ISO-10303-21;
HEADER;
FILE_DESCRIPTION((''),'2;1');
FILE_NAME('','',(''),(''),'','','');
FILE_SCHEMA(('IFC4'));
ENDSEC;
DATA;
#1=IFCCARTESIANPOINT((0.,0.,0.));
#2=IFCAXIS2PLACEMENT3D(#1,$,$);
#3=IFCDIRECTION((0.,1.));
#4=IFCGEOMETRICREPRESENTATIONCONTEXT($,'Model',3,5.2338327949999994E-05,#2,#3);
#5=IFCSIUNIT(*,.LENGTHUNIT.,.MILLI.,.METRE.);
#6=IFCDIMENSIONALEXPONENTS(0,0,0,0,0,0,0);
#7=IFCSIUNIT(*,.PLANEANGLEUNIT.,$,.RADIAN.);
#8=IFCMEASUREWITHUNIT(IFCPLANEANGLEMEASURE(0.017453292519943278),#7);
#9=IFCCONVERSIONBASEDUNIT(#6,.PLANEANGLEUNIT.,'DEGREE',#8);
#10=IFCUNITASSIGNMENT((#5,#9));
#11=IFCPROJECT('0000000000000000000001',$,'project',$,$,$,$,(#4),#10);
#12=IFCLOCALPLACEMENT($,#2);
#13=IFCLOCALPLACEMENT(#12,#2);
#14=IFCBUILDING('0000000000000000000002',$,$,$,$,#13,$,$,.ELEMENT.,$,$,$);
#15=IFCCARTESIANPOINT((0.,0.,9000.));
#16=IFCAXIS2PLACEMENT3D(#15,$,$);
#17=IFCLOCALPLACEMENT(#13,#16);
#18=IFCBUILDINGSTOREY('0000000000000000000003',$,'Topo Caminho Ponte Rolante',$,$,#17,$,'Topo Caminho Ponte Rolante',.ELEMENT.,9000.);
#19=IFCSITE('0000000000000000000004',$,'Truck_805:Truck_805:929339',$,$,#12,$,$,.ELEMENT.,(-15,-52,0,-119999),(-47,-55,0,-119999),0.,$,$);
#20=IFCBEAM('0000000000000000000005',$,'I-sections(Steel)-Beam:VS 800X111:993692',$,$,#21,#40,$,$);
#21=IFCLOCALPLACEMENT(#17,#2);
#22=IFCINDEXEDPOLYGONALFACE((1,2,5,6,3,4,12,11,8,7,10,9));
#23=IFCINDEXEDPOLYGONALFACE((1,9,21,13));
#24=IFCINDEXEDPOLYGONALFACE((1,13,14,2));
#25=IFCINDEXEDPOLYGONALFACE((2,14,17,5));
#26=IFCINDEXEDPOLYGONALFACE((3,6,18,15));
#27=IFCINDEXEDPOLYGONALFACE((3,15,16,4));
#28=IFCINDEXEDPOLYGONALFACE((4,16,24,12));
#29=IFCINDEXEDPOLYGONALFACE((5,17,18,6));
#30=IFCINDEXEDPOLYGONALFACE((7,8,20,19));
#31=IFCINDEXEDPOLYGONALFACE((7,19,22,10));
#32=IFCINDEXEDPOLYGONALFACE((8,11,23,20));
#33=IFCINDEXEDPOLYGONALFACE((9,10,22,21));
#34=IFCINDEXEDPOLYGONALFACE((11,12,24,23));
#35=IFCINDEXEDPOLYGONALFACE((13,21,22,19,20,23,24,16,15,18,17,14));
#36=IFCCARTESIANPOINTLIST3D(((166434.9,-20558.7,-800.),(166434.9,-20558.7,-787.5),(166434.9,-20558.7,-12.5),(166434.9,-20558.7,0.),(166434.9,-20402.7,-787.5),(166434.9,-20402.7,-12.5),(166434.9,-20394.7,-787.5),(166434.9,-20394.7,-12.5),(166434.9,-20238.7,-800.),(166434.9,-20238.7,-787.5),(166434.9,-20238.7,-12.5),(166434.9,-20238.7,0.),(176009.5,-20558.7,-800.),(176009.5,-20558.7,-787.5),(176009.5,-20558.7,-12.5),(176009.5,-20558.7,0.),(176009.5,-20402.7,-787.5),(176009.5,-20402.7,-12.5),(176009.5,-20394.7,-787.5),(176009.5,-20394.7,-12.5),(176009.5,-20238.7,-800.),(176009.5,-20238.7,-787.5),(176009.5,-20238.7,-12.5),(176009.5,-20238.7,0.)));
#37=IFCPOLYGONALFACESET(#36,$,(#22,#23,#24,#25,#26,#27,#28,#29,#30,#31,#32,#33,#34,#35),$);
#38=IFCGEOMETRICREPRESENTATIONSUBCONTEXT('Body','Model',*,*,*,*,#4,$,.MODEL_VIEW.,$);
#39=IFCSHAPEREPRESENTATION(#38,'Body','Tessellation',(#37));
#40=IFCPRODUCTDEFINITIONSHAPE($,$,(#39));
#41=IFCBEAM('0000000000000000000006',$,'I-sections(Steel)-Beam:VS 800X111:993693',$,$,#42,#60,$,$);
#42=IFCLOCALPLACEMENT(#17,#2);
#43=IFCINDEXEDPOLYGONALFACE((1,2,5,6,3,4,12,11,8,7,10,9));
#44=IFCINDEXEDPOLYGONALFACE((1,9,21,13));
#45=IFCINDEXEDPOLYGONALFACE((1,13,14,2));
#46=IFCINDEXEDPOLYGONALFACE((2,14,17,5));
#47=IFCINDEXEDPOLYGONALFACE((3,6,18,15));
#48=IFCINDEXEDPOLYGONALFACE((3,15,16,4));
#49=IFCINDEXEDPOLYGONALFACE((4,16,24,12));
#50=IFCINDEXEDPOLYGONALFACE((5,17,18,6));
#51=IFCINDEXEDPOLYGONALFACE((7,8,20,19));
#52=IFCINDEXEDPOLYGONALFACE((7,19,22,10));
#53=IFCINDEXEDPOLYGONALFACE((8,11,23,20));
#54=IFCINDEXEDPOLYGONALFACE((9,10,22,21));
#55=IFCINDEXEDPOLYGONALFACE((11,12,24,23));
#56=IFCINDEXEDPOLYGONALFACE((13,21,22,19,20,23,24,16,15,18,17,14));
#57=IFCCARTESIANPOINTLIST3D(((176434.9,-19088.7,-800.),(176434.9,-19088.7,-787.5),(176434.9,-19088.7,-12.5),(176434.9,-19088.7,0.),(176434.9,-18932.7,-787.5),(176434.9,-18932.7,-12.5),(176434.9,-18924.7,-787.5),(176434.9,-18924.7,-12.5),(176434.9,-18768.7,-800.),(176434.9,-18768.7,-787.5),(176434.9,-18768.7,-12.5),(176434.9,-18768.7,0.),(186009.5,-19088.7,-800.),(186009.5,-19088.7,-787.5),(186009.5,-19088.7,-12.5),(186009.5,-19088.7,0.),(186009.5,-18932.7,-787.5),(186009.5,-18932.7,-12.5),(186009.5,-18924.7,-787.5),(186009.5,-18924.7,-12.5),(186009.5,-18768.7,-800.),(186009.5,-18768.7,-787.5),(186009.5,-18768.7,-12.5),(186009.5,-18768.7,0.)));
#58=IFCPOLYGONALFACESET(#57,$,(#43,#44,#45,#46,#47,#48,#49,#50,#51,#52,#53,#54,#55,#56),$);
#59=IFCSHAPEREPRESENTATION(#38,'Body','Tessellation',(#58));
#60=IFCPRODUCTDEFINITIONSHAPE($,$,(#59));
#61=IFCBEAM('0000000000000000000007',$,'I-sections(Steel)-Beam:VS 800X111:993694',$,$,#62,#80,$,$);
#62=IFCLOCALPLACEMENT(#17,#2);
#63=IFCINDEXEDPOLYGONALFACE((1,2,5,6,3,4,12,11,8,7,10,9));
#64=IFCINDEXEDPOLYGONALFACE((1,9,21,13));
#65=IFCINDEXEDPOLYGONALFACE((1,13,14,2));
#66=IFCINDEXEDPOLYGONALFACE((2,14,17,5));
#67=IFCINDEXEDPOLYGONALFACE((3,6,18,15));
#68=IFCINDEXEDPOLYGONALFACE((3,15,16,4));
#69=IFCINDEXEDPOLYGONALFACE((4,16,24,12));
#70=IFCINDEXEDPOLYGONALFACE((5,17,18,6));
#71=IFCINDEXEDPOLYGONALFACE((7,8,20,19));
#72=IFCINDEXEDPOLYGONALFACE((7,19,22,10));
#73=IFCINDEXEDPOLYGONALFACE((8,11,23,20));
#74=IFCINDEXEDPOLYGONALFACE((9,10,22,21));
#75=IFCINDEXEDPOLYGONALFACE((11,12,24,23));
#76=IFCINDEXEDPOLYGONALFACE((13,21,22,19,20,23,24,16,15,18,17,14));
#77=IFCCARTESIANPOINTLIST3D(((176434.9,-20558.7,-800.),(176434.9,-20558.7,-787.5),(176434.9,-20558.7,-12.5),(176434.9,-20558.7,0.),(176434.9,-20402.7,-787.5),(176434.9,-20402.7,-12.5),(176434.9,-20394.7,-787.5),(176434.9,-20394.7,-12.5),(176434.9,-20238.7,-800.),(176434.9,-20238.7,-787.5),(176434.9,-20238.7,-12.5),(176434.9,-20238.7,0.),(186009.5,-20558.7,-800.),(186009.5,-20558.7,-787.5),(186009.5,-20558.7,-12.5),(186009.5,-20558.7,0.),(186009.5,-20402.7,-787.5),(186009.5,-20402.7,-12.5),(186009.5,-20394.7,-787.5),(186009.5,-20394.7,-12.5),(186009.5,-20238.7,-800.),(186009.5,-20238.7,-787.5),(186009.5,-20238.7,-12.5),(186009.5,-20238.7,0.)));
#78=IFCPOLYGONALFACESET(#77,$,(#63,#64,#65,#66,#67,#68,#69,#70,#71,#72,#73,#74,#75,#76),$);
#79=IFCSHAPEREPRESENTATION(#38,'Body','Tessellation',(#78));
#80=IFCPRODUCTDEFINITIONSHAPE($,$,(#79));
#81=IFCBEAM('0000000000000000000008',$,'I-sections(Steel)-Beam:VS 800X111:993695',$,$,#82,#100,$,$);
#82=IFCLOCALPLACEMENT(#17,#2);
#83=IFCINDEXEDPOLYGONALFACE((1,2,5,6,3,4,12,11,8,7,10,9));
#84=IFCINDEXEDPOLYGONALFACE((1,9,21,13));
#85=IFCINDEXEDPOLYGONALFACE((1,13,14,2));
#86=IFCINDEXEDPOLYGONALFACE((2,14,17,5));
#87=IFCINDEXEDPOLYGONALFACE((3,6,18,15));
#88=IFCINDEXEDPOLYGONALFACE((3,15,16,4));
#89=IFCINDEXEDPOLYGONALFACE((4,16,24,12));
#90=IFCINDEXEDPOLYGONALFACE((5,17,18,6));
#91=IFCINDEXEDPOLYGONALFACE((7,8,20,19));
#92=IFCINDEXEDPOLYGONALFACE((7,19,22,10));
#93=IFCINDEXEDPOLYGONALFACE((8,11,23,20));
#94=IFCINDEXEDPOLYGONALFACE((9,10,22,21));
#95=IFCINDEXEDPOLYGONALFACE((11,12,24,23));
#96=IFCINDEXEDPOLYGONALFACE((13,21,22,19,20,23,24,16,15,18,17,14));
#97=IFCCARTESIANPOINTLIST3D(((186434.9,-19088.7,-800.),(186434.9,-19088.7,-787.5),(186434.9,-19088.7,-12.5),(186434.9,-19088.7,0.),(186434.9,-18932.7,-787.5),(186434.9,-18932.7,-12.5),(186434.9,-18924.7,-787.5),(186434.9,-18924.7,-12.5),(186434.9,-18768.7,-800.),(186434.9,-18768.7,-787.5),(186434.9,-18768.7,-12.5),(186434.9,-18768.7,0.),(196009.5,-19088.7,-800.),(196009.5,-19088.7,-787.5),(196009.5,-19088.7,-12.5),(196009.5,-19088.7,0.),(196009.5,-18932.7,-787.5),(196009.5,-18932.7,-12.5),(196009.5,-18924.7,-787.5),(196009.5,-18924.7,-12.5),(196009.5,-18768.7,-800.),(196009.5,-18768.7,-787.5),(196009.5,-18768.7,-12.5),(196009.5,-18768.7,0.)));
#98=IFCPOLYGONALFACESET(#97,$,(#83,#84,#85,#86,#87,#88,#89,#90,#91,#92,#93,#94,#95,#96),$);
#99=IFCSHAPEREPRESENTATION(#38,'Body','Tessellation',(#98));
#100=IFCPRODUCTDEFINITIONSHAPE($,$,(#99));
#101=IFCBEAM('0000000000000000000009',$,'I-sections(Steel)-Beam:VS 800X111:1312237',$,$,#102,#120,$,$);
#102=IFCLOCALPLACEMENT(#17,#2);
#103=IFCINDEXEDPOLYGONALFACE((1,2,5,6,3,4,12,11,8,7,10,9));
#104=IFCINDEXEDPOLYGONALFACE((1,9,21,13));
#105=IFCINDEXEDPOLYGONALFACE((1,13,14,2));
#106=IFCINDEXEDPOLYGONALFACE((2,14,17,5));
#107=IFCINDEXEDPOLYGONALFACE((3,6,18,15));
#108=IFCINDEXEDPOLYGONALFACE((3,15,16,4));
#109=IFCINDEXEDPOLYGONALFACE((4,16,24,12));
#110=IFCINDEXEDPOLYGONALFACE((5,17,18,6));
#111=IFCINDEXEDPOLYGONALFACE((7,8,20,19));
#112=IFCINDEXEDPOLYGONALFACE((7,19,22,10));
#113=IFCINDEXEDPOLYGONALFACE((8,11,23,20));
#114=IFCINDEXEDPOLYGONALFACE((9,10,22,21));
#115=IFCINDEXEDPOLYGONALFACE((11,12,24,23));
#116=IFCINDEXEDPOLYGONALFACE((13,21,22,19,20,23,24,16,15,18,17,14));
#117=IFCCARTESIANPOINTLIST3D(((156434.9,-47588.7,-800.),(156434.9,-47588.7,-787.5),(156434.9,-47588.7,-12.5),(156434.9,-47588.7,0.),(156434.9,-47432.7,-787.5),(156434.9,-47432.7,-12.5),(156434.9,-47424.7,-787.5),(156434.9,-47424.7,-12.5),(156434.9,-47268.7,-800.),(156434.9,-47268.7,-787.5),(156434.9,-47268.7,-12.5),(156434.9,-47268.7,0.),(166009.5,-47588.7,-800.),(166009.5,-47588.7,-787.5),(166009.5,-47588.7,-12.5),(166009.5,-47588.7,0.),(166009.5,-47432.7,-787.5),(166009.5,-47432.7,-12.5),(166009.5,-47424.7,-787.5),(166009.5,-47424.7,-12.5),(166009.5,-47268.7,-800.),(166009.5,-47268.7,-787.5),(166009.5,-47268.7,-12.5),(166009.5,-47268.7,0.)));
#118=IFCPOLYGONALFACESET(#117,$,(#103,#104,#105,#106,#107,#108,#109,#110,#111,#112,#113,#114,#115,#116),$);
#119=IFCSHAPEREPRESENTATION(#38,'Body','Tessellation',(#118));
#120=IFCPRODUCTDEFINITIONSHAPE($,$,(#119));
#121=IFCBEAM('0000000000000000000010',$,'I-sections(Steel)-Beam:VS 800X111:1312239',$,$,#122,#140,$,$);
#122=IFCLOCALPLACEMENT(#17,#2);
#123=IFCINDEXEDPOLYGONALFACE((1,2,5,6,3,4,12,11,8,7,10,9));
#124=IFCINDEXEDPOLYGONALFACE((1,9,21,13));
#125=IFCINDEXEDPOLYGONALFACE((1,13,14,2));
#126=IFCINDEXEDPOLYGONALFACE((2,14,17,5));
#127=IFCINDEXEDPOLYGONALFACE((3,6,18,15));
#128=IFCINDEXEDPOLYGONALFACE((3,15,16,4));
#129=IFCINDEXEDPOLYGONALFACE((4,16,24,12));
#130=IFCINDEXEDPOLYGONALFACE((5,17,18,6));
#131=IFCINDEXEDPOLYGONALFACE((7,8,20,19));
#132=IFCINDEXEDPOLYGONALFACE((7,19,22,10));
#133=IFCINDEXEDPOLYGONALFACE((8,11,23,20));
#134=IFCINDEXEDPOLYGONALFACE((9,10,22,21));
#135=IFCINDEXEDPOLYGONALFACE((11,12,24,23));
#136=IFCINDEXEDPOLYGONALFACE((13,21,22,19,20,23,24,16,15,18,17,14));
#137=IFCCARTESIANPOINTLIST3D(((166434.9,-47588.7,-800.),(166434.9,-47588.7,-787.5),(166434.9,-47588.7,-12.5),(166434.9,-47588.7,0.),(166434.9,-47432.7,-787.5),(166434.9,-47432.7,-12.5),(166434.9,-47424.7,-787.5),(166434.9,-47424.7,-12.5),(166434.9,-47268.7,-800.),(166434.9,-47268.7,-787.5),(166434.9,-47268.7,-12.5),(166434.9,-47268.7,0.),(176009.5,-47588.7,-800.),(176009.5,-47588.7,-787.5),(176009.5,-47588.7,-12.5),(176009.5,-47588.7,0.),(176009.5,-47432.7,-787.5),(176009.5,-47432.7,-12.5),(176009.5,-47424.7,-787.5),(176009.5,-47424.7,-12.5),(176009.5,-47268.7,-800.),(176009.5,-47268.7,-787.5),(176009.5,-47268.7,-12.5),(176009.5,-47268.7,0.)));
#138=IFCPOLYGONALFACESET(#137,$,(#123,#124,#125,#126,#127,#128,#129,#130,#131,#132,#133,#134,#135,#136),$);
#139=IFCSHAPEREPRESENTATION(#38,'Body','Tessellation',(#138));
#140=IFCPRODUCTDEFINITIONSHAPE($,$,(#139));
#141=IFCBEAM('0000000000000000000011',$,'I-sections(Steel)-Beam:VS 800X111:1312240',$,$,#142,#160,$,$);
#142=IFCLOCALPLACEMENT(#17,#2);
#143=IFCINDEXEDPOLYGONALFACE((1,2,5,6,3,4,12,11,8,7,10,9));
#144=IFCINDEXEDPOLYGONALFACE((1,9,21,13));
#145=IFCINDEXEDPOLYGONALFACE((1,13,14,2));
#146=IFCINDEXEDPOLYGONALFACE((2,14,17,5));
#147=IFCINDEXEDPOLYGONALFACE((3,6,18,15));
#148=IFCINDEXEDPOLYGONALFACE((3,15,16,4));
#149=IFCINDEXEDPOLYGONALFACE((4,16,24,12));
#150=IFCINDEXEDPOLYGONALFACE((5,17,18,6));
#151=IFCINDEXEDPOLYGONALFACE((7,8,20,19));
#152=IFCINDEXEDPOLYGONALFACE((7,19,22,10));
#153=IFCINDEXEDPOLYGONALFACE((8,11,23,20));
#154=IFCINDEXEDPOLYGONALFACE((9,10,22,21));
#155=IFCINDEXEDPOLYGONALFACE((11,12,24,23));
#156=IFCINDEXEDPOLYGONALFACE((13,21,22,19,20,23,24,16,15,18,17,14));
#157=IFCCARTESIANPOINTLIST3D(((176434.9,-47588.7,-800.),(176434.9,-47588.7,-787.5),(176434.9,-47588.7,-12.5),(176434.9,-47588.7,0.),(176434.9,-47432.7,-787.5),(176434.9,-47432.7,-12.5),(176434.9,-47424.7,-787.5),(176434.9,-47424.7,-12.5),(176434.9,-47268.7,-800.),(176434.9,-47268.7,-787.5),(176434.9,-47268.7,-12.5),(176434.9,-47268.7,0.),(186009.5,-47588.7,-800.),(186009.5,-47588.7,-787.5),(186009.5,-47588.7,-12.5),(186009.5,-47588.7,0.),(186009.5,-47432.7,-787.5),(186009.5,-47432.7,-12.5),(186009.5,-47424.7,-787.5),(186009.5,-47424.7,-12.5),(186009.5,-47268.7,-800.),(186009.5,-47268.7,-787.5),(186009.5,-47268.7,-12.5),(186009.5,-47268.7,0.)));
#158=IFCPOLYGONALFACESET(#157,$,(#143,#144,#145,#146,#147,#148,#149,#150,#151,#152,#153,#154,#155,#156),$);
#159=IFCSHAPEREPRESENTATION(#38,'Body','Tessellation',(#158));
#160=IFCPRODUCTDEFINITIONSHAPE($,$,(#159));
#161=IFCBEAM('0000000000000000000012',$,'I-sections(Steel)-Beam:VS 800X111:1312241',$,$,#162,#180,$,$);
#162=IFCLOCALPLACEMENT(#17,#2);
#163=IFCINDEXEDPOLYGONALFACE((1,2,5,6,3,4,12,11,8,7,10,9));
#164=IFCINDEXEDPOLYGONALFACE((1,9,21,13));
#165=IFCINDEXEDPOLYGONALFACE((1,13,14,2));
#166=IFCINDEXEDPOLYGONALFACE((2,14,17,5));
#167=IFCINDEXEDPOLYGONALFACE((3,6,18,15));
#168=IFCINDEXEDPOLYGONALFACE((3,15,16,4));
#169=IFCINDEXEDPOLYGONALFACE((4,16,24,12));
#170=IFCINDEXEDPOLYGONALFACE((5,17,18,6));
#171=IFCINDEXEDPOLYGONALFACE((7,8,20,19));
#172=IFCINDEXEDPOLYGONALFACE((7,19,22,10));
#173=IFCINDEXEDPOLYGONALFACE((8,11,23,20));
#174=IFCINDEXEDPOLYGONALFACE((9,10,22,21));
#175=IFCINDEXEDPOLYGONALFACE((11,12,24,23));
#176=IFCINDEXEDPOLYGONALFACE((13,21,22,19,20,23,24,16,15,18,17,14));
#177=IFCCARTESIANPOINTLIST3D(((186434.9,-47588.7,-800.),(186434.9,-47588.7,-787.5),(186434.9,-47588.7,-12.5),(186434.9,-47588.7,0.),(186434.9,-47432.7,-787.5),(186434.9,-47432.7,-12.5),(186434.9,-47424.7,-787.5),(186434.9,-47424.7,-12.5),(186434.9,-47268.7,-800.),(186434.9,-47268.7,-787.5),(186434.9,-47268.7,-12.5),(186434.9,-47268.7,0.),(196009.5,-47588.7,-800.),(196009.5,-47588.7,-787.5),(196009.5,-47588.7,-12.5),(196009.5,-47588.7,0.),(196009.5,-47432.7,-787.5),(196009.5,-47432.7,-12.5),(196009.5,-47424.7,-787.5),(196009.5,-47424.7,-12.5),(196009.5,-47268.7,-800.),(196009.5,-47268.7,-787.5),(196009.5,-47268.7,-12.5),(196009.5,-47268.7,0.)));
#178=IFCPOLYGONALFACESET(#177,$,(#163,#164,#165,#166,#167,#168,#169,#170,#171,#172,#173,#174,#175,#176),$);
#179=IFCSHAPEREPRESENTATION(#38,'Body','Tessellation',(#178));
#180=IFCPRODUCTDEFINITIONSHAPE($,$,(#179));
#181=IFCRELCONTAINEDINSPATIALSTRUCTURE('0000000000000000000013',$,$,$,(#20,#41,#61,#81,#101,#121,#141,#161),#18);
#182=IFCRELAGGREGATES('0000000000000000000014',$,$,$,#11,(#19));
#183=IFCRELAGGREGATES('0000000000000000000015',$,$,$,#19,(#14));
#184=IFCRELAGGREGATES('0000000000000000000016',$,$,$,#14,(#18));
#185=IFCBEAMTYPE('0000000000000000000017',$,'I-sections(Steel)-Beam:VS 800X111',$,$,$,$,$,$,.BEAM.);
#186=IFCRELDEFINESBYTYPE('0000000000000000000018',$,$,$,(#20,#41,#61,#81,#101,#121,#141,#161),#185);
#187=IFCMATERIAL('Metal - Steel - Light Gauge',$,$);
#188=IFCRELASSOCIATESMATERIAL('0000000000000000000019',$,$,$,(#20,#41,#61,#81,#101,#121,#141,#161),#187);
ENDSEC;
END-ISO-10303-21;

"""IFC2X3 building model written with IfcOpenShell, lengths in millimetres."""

from ifc_helpers import new_model, entity, si_unit, converted_unit, direction, frame, frame_2d, origin, place, context, subcontext, project, spatial, polyline, i_section, outline, extrude, material, type_object, element, save


model = new_model("IFC2X3")

# Units and contexts
model_context = context("Model", 3, precision=5.2338327949999994e-05, world=origin(), true_north=direction((0.0, 1.0)))
body_context = subcontext(model_context, "Body", "Model", "MODEL_VIEW")
ifc_project = project(units=[si_unit("LENGTHUNIT", "METRE", prefix="MILLI"), converted_unit("PLANEANGLEUNIT", "DEGREE", entity("IfcPlaneAngleMeasure", 0.017453292519943278), si_unit("PLANEANGLEUNIT", "RADIAN"), dimensions=[0, 0, 0, 0, 0, 0, 0])], contexts=[model_context])

# Site, building, storey
site_placement = place(None, origin())
site = spatial("IfcSite", under=ifc_project, at=site_placement, Name="Truck_805:Truck_805:929339", CompositionType="ELEMENT", RefLatitude=(-15, -52, 0, -119999), RefLongitude=(-47, -55, 0, -119999), RefElevation=0.0)
building_placement = place(site_placement, origin())
building = spatial("IfcBuilding", under=site, at=building_placement, CompositionType="ELEMENT")
storey_placement = place(building_placement, frame((0.0, 0.0, 9000.0)))
storey = spatial("IfcBuildingStorey", under=building, at=storey_placement, Name="Topo Caminho Ponte Rolante", LongName="Topo Caminho Ponte Rolante", CompositionType="ELEMENT", Elevation=9000.0)

# Beams
ifc_material = material(Name="Metal - Steel - Light Gauge")
beam_type_1 = type_object("IfcBeamType", Name="I-sections(Steel)-Beam:VS 800X111", PredefinedType="BEAM")
beam_1_placement = place(storey_placement, frame((166222.2, -20398.7, 0.0)))
element("IfcBeam", 1, at=beam_1_placement, inside=storey, type_object=beam_type_1, material=ifc_material, Name="I-sections(Steel)-Beam:VS 800X111:993692", context=body_context, shape_type="SweptSolid", body=[
    extrude(outline(polyline([(387.5, -160.0), (400.0, -160.0), (400.0, 160.0), (387.5, 160.0), (387.5, 4.0), (-387.5, 4.0), (-387.5, 160.0), (-400.0, 160.0), (-400.0, -160.0), (-387.5, -160.0), (-387.5, -4.0), (387.5, -4.0), (387.5, -160.0)])), frame((212.7, 0.0, -400.0), z_axis=(1.0, 0.0, 0.0), x_axis=(0.0, 0.0, -1.0)), (0.0, 0.0, 1.0), 9574.6),
])
beam_2_placement = place(storey_placement, frame((176222.2, -18928.7, 0.0)))
element("IfcBeam", 2, at=beam_2_placement, inside=storey, type_object=beam_type_1, material=ifc_material, Name="I-sections(Steel)-Beam:VS 800X111:993693", context=body_context, shape_type="SweptSolid", body=[
    extrude(i_section(OverallWidth=320.0, OverallDepth=800.0, WebThickness=8.0, FlangeThickness=12.5, at=frame_2d((0.0, 0.0), x_axis=(0.0, 1.0))), frame((212.7, 0.0, -400.0), z_axis=(1.0, 0.0, 0.0), x_axis=(0.0, 0.0, -1.0)), (0.0, 0.0, 1.0), 9574.6),
])
beam_3_placement = place(storey_placement, frame((176222.2, -20398.7, 0.0)))
element("IfcBeam", 3, at=beam_3_placement, inside=storey, type_object=beam_type_1, material=ifc_material, Name="I-sections(Steel)-Beam:VS 800X111:993694", context=body_context, shape_type="SweptSolid", body=[
    extrude(outline(polyline([(387.5, -160.0), (400.0, -160.0), (400.0, 160.0), (387.5, 160.0), (387.5, 4.0), (-387.5, 4.0), (-387.5, 160.0), (-400.0, 160.0), (-400.0, -160.0), (-387.5, -160.0), (-387.5, -4.0), (387.5, -4.0), (387.5, -160.0)])), frame((212.7, 0.0, -400.0), z_axis=(1.0, 0.0, 0.0), x_axis=(0.0, 0.0, -1.0)), (0.0, 0.0, 1.0), 9574.6),
])
beam_4_placement = place(storey_placement, frame((186222.2, -18928.7, 0.0)))
element("IfcBeam", 4, at=beam_4_placement, inside=storey, type_object=beam_type_1, material=ifc_material, Name="I-sections(Steel)-Beam:VS 800X111:993695", context=body_context, shape_type="SweptSolid", body=[
    extrude(i_section(OverallWidth=320.0, OverallDepth=800.0, WebThickness=8.0, FlangeThickness=12.5, at=frame_2d((0.0, 0.0), x_axis=(0.0, 1.0))), frame((212.7, 0.0, -400.0), z_axis=(1.0, 0.0, 0.0), x_axis=(0.0, 0.0, -1.0)), (0.0, 0.0, 1.0), 9574.6),
])
beam_5_placement = place(storey_placement, frame((156222.2, -47428.7, 0.0)))
element("IfcBeam", 5, at=beam_5_placement, inside=storey, type_object=beam_type_1, material=ifc_material, Name="I-sections(Steel)-Beam:VS 800X111:1312237", context=body_context, shape_type="SweptSolid", body=[
    extrude(i_section(OverallWidth=320.0, OverallDepth=800.0, WebThickness=8.0, FlangeThickness=12.5, at=frame_2d((0.0, 0.0), x_axis=(0.0, 1.0))), frame((212.7, 0.0, -400.0), z_axis=(1.0, 0.0, 0.0), x_axis=(0.0, 0.0, -1.0)), (0.0, 0.0, 1.0), 9574.6),
])
for number, where, name in (
    (6, (166222.2, -47428.7, 0.0), "I-sections(Steel)-Beam:VS 800X111:1312239"),
    (7, (176222.2, -47428.7, 0.0), "I-sections(Steel)-Beam:VS 800X111:1312240"),
):
    element("IfcBeam", number, at=place(storey_placement, frame(where)), inside=storey, type_object=beam_type_1, material=ifc_material, Name=name, context=body_context, shape_type="SweptSolid", body=[
        extrude(i_section(OverallWidth=320.0, OverallDepth=800.0, WebThickness=8.0, FlangeThickness=12.5, at=frame_2d((0.0, 0.0), x_axis=(0.0, 1.0))), frame((212.7, 0.0, -400.0), z_axis=(1.0, 0.0, 0.0), x_axis=(0.0, 0.0, -1.0)), (0.0, 0.0, 1.0), 9574.6),
    ])
beam_6_placement = place(storey_placement, frame((186222.2, -47428.7, 0.0)))
element("IfcBeam", 8, at=beam_6_placement, inside=storey, type_object=beam_type_1, material=ifc_material, Name="I-sections(Steel)-Beam:VS 800X111:1312241", context=body_context, shape_type="SweptSolid", body=[
    extrude(i_section(OverallWidth=320.0, OverallDepth=800.0, WebThickness=8.0, FlangeThickness=12.5, at=frame_2d((0.0, 0.0), x_axis=(0.0, 1.0))), frame((212.7, 0.0, -400.0), z_axis=(1.0, 0.0, 0.0), x_axis=(0.0, 0.0, -1.0)), (0.0, 0.0, 1.0), 9574.6),
])

save(model, "model.ifc")
